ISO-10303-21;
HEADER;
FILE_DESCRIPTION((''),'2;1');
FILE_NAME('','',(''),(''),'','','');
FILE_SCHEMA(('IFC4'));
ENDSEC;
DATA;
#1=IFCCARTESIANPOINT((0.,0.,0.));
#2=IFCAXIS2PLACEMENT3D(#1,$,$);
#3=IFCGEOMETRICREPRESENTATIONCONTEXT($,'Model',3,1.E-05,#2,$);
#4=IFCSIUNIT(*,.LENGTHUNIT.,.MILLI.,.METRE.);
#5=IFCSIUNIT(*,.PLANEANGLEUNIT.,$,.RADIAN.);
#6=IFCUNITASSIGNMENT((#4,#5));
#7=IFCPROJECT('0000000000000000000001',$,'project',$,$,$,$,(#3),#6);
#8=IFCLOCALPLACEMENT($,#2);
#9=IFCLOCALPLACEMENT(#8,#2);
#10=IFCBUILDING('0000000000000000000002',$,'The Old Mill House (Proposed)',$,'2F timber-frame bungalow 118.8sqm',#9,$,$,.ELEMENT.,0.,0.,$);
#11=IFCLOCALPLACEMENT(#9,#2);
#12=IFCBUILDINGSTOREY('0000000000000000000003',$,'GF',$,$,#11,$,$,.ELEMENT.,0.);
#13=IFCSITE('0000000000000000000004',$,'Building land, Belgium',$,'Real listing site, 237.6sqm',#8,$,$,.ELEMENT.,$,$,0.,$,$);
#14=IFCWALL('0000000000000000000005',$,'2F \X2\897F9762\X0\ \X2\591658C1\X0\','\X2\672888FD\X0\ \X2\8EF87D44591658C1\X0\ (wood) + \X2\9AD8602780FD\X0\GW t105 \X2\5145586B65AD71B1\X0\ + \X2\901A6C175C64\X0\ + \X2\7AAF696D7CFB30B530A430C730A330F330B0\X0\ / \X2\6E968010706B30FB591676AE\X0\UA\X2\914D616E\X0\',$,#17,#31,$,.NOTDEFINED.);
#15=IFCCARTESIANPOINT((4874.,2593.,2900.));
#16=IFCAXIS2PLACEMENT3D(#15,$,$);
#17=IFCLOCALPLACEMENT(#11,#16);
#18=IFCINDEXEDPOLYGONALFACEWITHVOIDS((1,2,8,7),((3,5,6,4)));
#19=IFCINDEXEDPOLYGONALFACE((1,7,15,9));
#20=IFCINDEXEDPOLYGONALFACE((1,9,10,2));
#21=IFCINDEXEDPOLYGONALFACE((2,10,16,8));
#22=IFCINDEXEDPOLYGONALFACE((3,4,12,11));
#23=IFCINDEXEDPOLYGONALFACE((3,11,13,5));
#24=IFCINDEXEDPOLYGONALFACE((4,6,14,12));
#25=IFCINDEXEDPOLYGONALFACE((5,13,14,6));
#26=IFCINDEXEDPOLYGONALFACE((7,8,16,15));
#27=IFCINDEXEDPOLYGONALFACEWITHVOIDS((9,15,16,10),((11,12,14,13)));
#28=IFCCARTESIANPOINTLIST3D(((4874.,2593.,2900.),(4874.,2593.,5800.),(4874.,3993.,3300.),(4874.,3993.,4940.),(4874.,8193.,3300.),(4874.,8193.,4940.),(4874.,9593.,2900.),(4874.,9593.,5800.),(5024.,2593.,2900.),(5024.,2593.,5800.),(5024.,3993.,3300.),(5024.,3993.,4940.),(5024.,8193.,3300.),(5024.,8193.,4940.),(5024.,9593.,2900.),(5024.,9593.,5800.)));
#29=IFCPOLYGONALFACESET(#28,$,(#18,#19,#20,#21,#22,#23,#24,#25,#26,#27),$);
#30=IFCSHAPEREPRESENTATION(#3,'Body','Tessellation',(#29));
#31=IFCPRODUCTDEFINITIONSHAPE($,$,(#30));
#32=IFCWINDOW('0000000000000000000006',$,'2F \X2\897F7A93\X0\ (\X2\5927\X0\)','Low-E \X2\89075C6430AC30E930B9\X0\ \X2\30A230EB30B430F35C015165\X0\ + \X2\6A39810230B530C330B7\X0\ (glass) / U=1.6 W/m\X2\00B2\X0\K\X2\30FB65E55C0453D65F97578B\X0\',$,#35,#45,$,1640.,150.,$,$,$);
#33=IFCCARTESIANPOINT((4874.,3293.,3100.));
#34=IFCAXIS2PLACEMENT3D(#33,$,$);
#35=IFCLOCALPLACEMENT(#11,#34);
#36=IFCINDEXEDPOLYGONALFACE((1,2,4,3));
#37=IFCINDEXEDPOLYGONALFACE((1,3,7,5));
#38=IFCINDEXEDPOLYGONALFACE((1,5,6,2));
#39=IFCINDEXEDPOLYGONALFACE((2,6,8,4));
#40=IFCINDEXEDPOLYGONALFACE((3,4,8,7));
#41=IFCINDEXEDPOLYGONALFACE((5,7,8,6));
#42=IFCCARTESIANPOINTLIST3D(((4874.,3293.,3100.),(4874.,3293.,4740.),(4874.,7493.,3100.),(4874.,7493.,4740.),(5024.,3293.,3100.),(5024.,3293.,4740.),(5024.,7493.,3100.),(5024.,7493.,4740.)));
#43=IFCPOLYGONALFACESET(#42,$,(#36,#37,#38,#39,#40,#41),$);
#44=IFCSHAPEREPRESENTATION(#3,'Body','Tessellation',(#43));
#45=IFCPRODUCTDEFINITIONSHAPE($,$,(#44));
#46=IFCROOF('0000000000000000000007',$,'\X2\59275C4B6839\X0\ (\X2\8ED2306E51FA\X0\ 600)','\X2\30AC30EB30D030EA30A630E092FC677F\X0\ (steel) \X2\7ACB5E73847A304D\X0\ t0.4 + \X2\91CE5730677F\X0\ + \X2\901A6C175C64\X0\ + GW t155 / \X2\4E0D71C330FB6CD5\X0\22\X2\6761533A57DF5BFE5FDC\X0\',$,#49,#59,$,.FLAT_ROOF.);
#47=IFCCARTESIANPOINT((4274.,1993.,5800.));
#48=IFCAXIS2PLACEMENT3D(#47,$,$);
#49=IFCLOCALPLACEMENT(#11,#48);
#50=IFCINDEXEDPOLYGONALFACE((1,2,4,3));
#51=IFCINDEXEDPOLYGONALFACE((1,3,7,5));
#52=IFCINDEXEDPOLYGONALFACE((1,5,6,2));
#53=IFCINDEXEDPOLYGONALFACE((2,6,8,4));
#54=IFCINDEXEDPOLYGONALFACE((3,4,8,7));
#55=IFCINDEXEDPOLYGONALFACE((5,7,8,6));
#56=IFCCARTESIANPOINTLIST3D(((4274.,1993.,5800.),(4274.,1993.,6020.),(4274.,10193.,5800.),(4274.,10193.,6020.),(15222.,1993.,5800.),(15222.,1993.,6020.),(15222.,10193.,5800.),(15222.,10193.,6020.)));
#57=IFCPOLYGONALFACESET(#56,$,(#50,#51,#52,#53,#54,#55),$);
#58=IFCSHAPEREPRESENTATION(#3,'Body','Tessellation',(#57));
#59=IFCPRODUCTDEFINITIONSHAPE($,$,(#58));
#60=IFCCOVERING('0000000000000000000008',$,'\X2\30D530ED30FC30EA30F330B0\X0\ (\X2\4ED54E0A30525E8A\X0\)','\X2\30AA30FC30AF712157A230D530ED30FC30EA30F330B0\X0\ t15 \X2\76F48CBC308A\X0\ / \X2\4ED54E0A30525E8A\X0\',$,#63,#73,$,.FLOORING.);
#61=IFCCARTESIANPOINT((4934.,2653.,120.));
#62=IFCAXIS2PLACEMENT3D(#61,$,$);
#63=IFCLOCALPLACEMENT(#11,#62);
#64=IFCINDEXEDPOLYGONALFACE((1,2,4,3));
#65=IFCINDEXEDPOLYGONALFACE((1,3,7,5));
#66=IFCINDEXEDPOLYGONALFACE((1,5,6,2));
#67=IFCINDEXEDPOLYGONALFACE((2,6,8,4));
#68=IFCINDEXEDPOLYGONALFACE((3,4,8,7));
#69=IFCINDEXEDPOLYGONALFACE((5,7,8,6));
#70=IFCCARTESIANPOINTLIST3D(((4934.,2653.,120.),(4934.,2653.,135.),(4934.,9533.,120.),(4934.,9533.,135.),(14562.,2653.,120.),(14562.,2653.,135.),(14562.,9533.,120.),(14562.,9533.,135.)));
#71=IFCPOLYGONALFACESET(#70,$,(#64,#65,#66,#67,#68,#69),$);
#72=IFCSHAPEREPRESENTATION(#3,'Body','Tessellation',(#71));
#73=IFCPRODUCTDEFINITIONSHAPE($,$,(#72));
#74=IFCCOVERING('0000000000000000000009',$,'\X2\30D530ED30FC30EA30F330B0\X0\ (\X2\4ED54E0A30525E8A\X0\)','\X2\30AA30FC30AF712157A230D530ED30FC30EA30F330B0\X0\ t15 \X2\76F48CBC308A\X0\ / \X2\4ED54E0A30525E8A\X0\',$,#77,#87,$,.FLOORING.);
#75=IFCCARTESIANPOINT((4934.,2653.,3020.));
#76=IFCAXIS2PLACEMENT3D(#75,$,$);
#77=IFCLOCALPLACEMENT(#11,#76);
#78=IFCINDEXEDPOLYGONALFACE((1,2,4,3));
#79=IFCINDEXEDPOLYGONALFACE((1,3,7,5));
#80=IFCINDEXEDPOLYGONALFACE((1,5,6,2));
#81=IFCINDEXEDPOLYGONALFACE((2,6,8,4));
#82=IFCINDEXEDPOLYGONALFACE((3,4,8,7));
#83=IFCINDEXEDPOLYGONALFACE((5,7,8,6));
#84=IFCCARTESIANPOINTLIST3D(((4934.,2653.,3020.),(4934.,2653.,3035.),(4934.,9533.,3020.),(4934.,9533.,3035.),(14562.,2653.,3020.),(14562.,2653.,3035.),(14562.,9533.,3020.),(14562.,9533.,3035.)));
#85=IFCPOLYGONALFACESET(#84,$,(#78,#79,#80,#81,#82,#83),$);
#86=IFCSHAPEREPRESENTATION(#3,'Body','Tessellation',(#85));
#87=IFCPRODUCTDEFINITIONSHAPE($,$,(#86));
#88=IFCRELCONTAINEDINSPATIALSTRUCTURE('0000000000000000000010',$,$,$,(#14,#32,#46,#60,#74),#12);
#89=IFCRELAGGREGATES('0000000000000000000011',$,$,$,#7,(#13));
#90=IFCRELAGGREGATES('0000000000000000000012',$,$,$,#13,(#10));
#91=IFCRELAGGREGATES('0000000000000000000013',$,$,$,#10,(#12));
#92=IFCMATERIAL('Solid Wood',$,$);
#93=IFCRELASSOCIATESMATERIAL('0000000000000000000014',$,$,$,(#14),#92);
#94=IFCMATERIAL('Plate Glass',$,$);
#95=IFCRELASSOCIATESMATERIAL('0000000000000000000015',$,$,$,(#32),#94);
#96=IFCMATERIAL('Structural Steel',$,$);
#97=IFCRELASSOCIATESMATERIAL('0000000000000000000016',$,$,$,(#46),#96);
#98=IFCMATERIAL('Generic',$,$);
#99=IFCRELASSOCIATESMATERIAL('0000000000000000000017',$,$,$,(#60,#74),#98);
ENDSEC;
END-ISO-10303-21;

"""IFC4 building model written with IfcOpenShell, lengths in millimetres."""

from ifc_helpers import new_model, si_unit, frame, frame_2d, origin, place, context, project, spatial, rectangle, extrude, material, element, fill, save


model = new_model("IFC4")

# Units and contexts
model_context = context("Model", 3, precision=1e-05, world=origin())
ifc_project = project(units=[si_unit("LENGTHUNIT", "METRE", prefix="MILLI"), si_unit("PLANEANGLEUNIT", "RADIAN")], contexts=[model_context])

# Site, building, storey
site_placement = place(None, origin())
site = spatial("IfcSite", under=ifc_project, at=site_placement, Name="Building land, Belgium", ObjectType="Real listing site, 237.6sqm", CompositionType="ELEMENT", RefElevation=0.0)
building_placement = place(site_placement, origin())
building = spatial("IfcBuilding", under=site, at=building_placement, Name="The Old Mill House (Proposed)", ObjectType="2F timber-frame bungalow 118.8sqm", CompositionType="ELEMENT", ElevationOfRefHeight=0.0, ElevationOfTerrain=0.0)
storey_placement = place(building_placement, origin())
storey = spatial("IfcBuildingStorey", under=building, at=storey_placement, Name="GF", CompositionType="ELEMENT", Elevation=0.0)

# Shared definitions
ifc_material_1 = material(Name="Solid Wood")

# Shared definitions
ifc_material_2 = material(Name="Plate Glass")

# Wall, opening, window
wall_1_placement = place(storey_placement, frame((4874.0, 2593.0, 2900.0)))
wall_1 = element("IfcWall", 1, at=wall_1_placement, inside=storey, material=ifc_material_1, Name="2F 西面 外壁", Description="木製 軸組外壁 (wood) + 高性能GW t105 充填断熱 + 通気層 + 窯業系サイディング / 準耐火・外皮UA配慮", PredefinedType="NOTDEFINED", context=model_context, shape_type="SweptSolid", body=[
    extrude(rectangle(XDim=150.0, YDim=7000.0, at=frame_2d((75.0, 3500.0))), frame((4874.0, 2593.0, 2900.0)), (0.0, 0.0, 1.0), 2900.0),
])
opening_1_placement = place(storey_placement, frame((4874.0, 3293.0, 3100.0)))
opening_1 = element("IfcOpeningElement", 2, at=opening_1_placement, cuts=wall_1, PredefinedType="NOTDEFINED", context=model_context, shape_type="SweptSolid", body=[
    extrude(rectangle(XDim=150.0, YDim=4200.0, at=frame_2d((75.0, 2100.0))), frame((4874.0, 3293.0, 3100.0)), (0.0, 0.0, 1.0), 1640.0),
])
window_1_placement = place(storey_placement, frame((4874.0, 3293.0, 3100.0)))
window_1 = element("IfcWindow", 3, at=window_1_placement, inside=storey, material=ifc_material_2, Name="2F 西窓 (大)", Description="Low-E 複層ガラス アルゴン封入 + 樹脂サッシ (glass) / U=1.6 W/m²K・日射取得型", OverallHeight=1640.0, OverallWidth=150.0, context=model_context, shape_type="SweptSolid", body=[
    extrude(rectangle(XDim=150.0, YDim=4200.0, at=frame_2d((75.0, 2100.0))), frame((4874.0, 3293.0, 3100.0)), (0.0, 0.0, 1.0), 1640.0),
])
fill(opening_1, window_1)

# Roof
ifc_material_3 = material(Name="Structural Steel")
roof_placement = place(storey_placement, frame((4274.0, 1993.0, 5800.0)))
element("IfcRoof", 4, at=roof_placement, inside=storey, material=ifc_material_3, Name="大屋根 (軒の出 600)", Description="ガルバリウム鋼板 (steel) 立平葺き t0.4 + 野地板 + 通気層 + GW t155 / 不燃・法22条区域対応", PredefinedType="FLAT_ROOF", context=model_context, shape_type="SweptSolid", body=[
    extrude(rectangle(XDim=10948.0, YDim=8200.0, at=frame_2d((5474.0, 4100.0))), frame((4274.0, 1993.0, 5800.0)), (0.0, 0.0, 1.0), 220.0),
])

# Coverings
ifc_material_4 = material(Name="Generic")
covering_1_placement = place(storey_placement, frame((4934.0, 2653.0, 120.0)))
element("IfcCovering", 5, at=covering_1_placement, inside=storey, material=ifc_material_4, Name="フローリング (仕上げ床)", Description="オーク無垢フローリング t15 直貼り / 仕上げ床", PredefinedType="FLOORING", context=model_context, shape_type="SweptSolid", body=[
    extrude(rectangle(XDim=9628.0, YDim=6880.0, at=frame_2d((4814.0, 3440.0))), frame((4934.0, 2653.0, 120.0)), (0.0, 0.0, 1.0), 15.0),
])
covering_2_placement = place(storey_placement, frame((4934.0, 2653.0, 3020.0)))
element("IfcCovering", 6, at=covering_2_placement, inside=storey, material=ifc_material_4, Name="フローリング (仕上げ床)", Description="オーク無垢フローリング t15 直貼り / 仕上げ床", PredefinedType="FLOORING", context=model_context, shape_type="SweptSolid", body=[
    extrude(rectangle(XDim=9628.0, YDim=6880.0, at=frame_2d((4814.0, 3440.0))), frame((4934.0, 2653.0, 3020.0)), (0.0, 0.0, 1.0), 15.0),
])

save(model, "model.ifc")
